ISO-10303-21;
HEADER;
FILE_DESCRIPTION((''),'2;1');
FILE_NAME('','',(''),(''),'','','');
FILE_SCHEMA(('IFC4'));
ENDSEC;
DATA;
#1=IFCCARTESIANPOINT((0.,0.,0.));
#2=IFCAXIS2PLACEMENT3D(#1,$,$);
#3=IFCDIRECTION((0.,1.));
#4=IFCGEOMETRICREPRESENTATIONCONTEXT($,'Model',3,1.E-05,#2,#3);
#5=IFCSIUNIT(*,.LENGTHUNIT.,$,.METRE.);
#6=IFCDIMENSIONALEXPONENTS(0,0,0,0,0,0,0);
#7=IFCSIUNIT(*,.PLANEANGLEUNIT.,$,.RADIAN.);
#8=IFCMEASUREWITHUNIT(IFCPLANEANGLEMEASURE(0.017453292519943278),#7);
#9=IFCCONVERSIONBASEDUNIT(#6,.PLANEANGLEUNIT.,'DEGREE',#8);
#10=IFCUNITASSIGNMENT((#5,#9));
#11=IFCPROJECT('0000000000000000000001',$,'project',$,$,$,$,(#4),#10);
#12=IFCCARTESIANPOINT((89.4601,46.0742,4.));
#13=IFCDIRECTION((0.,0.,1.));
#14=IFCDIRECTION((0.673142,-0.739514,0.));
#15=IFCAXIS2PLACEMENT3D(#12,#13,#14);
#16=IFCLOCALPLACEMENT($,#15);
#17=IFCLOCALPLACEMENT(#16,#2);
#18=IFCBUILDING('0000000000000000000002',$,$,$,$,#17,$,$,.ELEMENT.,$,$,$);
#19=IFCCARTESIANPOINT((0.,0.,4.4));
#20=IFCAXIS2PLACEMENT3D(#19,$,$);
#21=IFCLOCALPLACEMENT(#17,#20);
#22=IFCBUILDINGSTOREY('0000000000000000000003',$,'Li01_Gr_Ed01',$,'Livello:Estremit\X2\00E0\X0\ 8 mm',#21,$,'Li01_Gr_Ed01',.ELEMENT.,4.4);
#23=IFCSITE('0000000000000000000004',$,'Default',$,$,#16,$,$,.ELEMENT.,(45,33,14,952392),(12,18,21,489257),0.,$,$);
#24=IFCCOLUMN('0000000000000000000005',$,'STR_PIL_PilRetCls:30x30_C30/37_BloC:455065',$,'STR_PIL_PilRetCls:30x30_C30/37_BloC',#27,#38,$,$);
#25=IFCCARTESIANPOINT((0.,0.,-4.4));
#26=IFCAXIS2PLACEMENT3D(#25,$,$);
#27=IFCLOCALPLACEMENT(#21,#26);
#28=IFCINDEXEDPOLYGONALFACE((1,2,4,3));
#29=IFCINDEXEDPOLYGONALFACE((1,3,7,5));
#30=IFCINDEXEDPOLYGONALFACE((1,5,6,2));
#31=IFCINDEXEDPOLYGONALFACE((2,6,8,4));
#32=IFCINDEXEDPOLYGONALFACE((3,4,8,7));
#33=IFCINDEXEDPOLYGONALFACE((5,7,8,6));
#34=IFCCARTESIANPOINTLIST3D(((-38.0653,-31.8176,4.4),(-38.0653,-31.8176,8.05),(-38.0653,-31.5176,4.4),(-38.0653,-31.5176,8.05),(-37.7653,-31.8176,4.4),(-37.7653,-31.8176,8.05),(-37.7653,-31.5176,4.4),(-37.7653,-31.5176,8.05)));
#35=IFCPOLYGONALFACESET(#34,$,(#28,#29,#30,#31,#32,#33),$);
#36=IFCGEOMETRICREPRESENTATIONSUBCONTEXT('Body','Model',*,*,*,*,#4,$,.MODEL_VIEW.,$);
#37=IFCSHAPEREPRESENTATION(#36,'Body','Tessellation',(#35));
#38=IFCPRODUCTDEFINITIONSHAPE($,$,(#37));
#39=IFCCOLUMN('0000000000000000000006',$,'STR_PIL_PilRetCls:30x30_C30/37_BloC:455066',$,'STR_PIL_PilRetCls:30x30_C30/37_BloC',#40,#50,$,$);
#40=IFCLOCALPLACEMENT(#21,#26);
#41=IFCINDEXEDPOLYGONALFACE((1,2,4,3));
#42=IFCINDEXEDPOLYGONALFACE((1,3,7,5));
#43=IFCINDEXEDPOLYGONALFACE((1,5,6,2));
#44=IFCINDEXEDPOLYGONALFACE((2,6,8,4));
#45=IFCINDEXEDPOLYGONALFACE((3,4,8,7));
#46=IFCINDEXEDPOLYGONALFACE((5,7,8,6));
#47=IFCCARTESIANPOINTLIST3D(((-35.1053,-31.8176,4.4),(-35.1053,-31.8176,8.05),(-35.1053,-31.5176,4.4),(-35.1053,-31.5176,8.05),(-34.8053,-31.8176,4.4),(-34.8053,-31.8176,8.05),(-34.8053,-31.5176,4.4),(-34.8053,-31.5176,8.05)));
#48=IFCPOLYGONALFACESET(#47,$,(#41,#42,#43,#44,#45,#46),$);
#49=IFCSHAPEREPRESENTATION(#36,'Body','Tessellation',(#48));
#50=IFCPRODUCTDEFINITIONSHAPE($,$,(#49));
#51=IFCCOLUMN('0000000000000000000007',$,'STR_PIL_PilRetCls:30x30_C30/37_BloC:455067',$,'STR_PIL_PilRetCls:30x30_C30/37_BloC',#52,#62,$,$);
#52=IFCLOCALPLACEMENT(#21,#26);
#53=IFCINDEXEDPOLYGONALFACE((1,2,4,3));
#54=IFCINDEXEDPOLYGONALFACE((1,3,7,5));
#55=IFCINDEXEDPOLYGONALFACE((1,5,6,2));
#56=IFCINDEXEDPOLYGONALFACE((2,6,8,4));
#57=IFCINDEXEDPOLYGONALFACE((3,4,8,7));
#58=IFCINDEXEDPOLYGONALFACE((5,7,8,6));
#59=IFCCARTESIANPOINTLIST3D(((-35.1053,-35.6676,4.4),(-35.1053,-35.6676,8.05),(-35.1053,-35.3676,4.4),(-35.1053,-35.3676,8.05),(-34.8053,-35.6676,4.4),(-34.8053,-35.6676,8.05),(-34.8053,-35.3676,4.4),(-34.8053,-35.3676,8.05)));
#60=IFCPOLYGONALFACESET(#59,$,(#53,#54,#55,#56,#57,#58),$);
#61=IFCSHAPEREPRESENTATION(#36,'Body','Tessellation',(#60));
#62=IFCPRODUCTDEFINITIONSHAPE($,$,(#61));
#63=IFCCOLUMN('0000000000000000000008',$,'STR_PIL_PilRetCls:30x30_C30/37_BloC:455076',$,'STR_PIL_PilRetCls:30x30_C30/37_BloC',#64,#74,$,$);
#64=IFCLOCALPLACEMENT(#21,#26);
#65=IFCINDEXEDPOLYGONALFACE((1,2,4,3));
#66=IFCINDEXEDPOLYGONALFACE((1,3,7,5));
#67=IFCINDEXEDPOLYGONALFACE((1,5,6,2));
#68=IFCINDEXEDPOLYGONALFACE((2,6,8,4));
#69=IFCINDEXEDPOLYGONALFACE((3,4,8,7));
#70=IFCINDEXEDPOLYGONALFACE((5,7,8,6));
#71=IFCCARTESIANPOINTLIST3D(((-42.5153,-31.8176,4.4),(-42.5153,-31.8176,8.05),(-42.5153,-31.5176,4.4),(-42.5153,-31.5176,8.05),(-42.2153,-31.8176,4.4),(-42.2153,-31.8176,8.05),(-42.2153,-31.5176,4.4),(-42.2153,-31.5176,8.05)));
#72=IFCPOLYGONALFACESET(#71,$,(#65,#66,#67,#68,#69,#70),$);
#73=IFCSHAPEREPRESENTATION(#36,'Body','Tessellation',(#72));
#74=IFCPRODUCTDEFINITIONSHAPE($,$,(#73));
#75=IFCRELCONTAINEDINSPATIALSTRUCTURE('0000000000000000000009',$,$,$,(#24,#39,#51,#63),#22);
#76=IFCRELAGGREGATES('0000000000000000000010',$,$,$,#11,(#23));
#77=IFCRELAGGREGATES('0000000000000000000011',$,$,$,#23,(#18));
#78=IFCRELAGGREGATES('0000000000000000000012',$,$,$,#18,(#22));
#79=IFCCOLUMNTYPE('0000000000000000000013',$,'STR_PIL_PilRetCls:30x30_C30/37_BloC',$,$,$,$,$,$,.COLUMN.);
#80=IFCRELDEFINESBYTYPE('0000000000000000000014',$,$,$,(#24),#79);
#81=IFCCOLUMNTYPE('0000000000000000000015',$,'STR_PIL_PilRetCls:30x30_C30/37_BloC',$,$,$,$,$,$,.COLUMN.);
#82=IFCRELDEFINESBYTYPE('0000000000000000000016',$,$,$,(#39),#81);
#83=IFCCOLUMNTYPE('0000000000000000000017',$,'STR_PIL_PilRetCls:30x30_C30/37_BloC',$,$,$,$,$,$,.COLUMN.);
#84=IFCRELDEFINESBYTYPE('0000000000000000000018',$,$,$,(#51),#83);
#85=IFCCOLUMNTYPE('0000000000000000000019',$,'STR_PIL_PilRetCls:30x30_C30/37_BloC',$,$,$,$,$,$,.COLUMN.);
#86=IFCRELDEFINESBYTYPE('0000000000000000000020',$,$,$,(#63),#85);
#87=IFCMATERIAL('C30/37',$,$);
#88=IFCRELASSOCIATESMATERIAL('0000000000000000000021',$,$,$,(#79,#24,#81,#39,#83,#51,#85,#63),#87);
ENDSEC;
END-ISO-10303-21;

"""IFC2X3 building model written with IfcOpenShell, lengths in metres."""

from ifc_helpers import new_model, entity, si_unit, converted_unit, direction, frame, origin, origin_2d_with_axis, place, context, subcontext, project, spatial, rectangle, extrude, source, transform, mapped, material, type_object, type_shapes, element, save


model = new_model("IFC2X3")

# Units and contexts
model_context = context("Model", 3, precision=1e-05, world=origin(), true_north=direction((0.0, 1.0)))
body_context = subcontext(model_context, "Body", "Model", "MODEL_VIEW")
ifc_project = project(units=[si_unit("LENGTHUNIT", "METRE"), converted_unit("PLANEANGLEUNIT", "DEGREE", entity("IfcPlaneAngleMeasure", 0.017453292519943278), si_unit("PLANEANGLEUNIT", "RADIAN"), dimensions=[0, 0, 0, 0, 0, 0, 0])], contexts=[model_context])

# Site, building, storey
site_placement = place(None, frame((89.4601, 46.0742, 4.0), z_axis=(0.0, 0.0, 1.0), x_axis=(0.673142, -0.739514, 0.0)))
site = spatial("IfcSite", under=ifc_project, at=site_placement, Name="Default", CompositionType="ELEMENT", RefLatitude=(45, 33, 14, 952392), RefLongitude=(12, 18, 21, 489257), RefElevation=0.0)
building_placement = place(site_placement, origin())
building = spatial("IfcBuilding", under=site, at=building_placement, CompositionType="ELEMENT")
storey_placement = place(building_placement, frame((0.0, 0.0, 4.4)))
storey = spatial("IfcBuildingStorey", under=building, at=storey_placement, Name="Li01_Gr_Ed01", ObjectType="Livello:Estremità 8 mm", LongName="Li01_Gr_Ed01", CompositionType="ELEMENT", Elevation=4.4)

# Columns
ifc_material_1 = material(Name="C30/37")
column_type_1 = type_object("IfcColumnType", Name="STR_PIL_PilRetCls:30x30_C30/37_BloC", PredefinedType="COLUMN", material=ifc_material_1)
shared_shape_1 = source(origin(), body_context, "Body", "SweptSolid", [
    extrude(rectangle(XDim=0.3, YDim=0.3, at=origin_2d_with_axis()), frame((-37.9153, -31.6676, 4.4), z_axis=(0.0, 0.0, 1.0), x_axis=(-1.0, 0.0, 0.0)), (0.0, 0.0, 1.0), 3.65),
])
type_shapes(column_type_1, [shared_shape_1])
column_1_placement = place(storey_placement, frame((0.0, 0.0, -4.4)))
element("IfcColumn", 1, at=column_1_placement, inside=storey, type_object=column_type_1, material=ifc_material_1, Name="STR_PIL_PilRetCls:30x30_C30/37_BloC:455065", ObjectType="STR_PIL_PilRetCls:30x30_C30/37_BloC", context=body_context, shape_type="MappedRepresentation", body=[
    mapped(shared_shape_1, transform((0.0, 0.0, 0.0), scale=1.0)),
])
column_type_2 = type_object("IfcColumnType", Name="STR_PIL_PilRetCls:30x30_C30/37_BloC", PredefinedType="COLUMN", material=ifc_material_1)
shared_shape_2 = source(origin(), body_context, "Body", "SweptSolid", [
    extrude(rectangle(XDim=0.3, YDim=0.3, at=origin_2d_with_axis()), frame((-34.9553, -31.6676, 4.4), z_axis=(0.0, 0.0, 1.0), x_axis=(-1.0, 0.0, 0.0)), (0.0, 0.0, 1.0), 3.65),
])
type_shapes(column_type_2, [shared_shape_2])
column_2_placement = place(storey_placement, frame((0.0, 0.0, -4.4)))
element("IfcColumn", 2, at=column_2_placement, inside=storey, type_object=column_type_2, material=ifc_material_1, Name="STR_PIL_PilRetCls:30x30_C30/37_BloC:455066", ObjectType="STR_PIL_PilRetCls:30x30_C30/37_BloC", context=body_context, shape_type="MappedRepresentation", body=[
    mapped(shared_shape_2, transform((0.0, 0.0, 0.0), scale=1.0)),
])
column_type_3 = type_object("IfcColumnType", Name="STR_PIL_PilRetCls:30x30_C30/37_BloC", PredefinedType="COLUMN", material=ifc_material_1)
shared_shape_3 = source(origin(), body_context, "Body", "SweptSolid", [
    extrude(rectangle(XDim=0.3, YDim=0.3, at=origin_2d_with_axis()), frame((-34.9553, -35.5176, 4.4), z_axis=(0.0, 0.0, 1.0), x_axis=(-1.0, 0.0, 0.0)), (0.0, 0.0, 1.0), 3.65),
])
type_shapes(column_type_3, [shared_shape_3])
column_3_placement = place(storey_placement, frame((0.0, 0.0, -4.4)))
element("IfcColumn", 3, at=column_3_placement, inside=storey, type_object=column_type_3, material=ifc_material_1, Name="STR_PIL_PilRetCls:30x30_C30/37_BloC:455067", ObjectType="STR_PIL_PilRetCls:30x30_C30/37_BloC", context=body_context, shape_type="MappedRepresentation", body=[
    mapped(shared_shape_3, transform((0.0, 0.0, 0.0), scale=1.0)),
])
column_type_4 = type_object("IfcColumnType", Name="STR_PIL_PilRetCls:30x30_C30/37_BloC", PredefinedType="COLUMN", material=ifc_material_1)
shared_shape_4 = source(origin(), body_context, "Body", "SweptSolid", [
    extrude(rectangle(XDim=0.3, YDim=0.3, at=origin_2d_with_axis()), frame((-42.3653, -31.6676, 4.4), z_axis=(0.0, 0.0, 1.0), x_axis=(-1.0, 0.0, 0.0)), (0.0, 0.0, 1.0), 3.65),
])
type_shapes(column_type_4, [shared_shape_4])
column_4_placement = place(storey_placement, frame((0.0, 0.0, -4.4)))
element("IfcColumn", 4, at=column_4_placement, inside=storey, type_object=column_type_4, material=ifc_material_1, Name="STR_PIL_PilRetCls:30x30_C30/37_BloC:455076", ObjectType="STR_PIL_PilRetCls:30x30_C30/37_BloC", context=body_context, shape_type="MappedRepresentation", body=[
    mapped(shared_shape_4, transform((0.0, 0.0, 0.0), scale=1.0)),
])

save(model, "model.ifc")
